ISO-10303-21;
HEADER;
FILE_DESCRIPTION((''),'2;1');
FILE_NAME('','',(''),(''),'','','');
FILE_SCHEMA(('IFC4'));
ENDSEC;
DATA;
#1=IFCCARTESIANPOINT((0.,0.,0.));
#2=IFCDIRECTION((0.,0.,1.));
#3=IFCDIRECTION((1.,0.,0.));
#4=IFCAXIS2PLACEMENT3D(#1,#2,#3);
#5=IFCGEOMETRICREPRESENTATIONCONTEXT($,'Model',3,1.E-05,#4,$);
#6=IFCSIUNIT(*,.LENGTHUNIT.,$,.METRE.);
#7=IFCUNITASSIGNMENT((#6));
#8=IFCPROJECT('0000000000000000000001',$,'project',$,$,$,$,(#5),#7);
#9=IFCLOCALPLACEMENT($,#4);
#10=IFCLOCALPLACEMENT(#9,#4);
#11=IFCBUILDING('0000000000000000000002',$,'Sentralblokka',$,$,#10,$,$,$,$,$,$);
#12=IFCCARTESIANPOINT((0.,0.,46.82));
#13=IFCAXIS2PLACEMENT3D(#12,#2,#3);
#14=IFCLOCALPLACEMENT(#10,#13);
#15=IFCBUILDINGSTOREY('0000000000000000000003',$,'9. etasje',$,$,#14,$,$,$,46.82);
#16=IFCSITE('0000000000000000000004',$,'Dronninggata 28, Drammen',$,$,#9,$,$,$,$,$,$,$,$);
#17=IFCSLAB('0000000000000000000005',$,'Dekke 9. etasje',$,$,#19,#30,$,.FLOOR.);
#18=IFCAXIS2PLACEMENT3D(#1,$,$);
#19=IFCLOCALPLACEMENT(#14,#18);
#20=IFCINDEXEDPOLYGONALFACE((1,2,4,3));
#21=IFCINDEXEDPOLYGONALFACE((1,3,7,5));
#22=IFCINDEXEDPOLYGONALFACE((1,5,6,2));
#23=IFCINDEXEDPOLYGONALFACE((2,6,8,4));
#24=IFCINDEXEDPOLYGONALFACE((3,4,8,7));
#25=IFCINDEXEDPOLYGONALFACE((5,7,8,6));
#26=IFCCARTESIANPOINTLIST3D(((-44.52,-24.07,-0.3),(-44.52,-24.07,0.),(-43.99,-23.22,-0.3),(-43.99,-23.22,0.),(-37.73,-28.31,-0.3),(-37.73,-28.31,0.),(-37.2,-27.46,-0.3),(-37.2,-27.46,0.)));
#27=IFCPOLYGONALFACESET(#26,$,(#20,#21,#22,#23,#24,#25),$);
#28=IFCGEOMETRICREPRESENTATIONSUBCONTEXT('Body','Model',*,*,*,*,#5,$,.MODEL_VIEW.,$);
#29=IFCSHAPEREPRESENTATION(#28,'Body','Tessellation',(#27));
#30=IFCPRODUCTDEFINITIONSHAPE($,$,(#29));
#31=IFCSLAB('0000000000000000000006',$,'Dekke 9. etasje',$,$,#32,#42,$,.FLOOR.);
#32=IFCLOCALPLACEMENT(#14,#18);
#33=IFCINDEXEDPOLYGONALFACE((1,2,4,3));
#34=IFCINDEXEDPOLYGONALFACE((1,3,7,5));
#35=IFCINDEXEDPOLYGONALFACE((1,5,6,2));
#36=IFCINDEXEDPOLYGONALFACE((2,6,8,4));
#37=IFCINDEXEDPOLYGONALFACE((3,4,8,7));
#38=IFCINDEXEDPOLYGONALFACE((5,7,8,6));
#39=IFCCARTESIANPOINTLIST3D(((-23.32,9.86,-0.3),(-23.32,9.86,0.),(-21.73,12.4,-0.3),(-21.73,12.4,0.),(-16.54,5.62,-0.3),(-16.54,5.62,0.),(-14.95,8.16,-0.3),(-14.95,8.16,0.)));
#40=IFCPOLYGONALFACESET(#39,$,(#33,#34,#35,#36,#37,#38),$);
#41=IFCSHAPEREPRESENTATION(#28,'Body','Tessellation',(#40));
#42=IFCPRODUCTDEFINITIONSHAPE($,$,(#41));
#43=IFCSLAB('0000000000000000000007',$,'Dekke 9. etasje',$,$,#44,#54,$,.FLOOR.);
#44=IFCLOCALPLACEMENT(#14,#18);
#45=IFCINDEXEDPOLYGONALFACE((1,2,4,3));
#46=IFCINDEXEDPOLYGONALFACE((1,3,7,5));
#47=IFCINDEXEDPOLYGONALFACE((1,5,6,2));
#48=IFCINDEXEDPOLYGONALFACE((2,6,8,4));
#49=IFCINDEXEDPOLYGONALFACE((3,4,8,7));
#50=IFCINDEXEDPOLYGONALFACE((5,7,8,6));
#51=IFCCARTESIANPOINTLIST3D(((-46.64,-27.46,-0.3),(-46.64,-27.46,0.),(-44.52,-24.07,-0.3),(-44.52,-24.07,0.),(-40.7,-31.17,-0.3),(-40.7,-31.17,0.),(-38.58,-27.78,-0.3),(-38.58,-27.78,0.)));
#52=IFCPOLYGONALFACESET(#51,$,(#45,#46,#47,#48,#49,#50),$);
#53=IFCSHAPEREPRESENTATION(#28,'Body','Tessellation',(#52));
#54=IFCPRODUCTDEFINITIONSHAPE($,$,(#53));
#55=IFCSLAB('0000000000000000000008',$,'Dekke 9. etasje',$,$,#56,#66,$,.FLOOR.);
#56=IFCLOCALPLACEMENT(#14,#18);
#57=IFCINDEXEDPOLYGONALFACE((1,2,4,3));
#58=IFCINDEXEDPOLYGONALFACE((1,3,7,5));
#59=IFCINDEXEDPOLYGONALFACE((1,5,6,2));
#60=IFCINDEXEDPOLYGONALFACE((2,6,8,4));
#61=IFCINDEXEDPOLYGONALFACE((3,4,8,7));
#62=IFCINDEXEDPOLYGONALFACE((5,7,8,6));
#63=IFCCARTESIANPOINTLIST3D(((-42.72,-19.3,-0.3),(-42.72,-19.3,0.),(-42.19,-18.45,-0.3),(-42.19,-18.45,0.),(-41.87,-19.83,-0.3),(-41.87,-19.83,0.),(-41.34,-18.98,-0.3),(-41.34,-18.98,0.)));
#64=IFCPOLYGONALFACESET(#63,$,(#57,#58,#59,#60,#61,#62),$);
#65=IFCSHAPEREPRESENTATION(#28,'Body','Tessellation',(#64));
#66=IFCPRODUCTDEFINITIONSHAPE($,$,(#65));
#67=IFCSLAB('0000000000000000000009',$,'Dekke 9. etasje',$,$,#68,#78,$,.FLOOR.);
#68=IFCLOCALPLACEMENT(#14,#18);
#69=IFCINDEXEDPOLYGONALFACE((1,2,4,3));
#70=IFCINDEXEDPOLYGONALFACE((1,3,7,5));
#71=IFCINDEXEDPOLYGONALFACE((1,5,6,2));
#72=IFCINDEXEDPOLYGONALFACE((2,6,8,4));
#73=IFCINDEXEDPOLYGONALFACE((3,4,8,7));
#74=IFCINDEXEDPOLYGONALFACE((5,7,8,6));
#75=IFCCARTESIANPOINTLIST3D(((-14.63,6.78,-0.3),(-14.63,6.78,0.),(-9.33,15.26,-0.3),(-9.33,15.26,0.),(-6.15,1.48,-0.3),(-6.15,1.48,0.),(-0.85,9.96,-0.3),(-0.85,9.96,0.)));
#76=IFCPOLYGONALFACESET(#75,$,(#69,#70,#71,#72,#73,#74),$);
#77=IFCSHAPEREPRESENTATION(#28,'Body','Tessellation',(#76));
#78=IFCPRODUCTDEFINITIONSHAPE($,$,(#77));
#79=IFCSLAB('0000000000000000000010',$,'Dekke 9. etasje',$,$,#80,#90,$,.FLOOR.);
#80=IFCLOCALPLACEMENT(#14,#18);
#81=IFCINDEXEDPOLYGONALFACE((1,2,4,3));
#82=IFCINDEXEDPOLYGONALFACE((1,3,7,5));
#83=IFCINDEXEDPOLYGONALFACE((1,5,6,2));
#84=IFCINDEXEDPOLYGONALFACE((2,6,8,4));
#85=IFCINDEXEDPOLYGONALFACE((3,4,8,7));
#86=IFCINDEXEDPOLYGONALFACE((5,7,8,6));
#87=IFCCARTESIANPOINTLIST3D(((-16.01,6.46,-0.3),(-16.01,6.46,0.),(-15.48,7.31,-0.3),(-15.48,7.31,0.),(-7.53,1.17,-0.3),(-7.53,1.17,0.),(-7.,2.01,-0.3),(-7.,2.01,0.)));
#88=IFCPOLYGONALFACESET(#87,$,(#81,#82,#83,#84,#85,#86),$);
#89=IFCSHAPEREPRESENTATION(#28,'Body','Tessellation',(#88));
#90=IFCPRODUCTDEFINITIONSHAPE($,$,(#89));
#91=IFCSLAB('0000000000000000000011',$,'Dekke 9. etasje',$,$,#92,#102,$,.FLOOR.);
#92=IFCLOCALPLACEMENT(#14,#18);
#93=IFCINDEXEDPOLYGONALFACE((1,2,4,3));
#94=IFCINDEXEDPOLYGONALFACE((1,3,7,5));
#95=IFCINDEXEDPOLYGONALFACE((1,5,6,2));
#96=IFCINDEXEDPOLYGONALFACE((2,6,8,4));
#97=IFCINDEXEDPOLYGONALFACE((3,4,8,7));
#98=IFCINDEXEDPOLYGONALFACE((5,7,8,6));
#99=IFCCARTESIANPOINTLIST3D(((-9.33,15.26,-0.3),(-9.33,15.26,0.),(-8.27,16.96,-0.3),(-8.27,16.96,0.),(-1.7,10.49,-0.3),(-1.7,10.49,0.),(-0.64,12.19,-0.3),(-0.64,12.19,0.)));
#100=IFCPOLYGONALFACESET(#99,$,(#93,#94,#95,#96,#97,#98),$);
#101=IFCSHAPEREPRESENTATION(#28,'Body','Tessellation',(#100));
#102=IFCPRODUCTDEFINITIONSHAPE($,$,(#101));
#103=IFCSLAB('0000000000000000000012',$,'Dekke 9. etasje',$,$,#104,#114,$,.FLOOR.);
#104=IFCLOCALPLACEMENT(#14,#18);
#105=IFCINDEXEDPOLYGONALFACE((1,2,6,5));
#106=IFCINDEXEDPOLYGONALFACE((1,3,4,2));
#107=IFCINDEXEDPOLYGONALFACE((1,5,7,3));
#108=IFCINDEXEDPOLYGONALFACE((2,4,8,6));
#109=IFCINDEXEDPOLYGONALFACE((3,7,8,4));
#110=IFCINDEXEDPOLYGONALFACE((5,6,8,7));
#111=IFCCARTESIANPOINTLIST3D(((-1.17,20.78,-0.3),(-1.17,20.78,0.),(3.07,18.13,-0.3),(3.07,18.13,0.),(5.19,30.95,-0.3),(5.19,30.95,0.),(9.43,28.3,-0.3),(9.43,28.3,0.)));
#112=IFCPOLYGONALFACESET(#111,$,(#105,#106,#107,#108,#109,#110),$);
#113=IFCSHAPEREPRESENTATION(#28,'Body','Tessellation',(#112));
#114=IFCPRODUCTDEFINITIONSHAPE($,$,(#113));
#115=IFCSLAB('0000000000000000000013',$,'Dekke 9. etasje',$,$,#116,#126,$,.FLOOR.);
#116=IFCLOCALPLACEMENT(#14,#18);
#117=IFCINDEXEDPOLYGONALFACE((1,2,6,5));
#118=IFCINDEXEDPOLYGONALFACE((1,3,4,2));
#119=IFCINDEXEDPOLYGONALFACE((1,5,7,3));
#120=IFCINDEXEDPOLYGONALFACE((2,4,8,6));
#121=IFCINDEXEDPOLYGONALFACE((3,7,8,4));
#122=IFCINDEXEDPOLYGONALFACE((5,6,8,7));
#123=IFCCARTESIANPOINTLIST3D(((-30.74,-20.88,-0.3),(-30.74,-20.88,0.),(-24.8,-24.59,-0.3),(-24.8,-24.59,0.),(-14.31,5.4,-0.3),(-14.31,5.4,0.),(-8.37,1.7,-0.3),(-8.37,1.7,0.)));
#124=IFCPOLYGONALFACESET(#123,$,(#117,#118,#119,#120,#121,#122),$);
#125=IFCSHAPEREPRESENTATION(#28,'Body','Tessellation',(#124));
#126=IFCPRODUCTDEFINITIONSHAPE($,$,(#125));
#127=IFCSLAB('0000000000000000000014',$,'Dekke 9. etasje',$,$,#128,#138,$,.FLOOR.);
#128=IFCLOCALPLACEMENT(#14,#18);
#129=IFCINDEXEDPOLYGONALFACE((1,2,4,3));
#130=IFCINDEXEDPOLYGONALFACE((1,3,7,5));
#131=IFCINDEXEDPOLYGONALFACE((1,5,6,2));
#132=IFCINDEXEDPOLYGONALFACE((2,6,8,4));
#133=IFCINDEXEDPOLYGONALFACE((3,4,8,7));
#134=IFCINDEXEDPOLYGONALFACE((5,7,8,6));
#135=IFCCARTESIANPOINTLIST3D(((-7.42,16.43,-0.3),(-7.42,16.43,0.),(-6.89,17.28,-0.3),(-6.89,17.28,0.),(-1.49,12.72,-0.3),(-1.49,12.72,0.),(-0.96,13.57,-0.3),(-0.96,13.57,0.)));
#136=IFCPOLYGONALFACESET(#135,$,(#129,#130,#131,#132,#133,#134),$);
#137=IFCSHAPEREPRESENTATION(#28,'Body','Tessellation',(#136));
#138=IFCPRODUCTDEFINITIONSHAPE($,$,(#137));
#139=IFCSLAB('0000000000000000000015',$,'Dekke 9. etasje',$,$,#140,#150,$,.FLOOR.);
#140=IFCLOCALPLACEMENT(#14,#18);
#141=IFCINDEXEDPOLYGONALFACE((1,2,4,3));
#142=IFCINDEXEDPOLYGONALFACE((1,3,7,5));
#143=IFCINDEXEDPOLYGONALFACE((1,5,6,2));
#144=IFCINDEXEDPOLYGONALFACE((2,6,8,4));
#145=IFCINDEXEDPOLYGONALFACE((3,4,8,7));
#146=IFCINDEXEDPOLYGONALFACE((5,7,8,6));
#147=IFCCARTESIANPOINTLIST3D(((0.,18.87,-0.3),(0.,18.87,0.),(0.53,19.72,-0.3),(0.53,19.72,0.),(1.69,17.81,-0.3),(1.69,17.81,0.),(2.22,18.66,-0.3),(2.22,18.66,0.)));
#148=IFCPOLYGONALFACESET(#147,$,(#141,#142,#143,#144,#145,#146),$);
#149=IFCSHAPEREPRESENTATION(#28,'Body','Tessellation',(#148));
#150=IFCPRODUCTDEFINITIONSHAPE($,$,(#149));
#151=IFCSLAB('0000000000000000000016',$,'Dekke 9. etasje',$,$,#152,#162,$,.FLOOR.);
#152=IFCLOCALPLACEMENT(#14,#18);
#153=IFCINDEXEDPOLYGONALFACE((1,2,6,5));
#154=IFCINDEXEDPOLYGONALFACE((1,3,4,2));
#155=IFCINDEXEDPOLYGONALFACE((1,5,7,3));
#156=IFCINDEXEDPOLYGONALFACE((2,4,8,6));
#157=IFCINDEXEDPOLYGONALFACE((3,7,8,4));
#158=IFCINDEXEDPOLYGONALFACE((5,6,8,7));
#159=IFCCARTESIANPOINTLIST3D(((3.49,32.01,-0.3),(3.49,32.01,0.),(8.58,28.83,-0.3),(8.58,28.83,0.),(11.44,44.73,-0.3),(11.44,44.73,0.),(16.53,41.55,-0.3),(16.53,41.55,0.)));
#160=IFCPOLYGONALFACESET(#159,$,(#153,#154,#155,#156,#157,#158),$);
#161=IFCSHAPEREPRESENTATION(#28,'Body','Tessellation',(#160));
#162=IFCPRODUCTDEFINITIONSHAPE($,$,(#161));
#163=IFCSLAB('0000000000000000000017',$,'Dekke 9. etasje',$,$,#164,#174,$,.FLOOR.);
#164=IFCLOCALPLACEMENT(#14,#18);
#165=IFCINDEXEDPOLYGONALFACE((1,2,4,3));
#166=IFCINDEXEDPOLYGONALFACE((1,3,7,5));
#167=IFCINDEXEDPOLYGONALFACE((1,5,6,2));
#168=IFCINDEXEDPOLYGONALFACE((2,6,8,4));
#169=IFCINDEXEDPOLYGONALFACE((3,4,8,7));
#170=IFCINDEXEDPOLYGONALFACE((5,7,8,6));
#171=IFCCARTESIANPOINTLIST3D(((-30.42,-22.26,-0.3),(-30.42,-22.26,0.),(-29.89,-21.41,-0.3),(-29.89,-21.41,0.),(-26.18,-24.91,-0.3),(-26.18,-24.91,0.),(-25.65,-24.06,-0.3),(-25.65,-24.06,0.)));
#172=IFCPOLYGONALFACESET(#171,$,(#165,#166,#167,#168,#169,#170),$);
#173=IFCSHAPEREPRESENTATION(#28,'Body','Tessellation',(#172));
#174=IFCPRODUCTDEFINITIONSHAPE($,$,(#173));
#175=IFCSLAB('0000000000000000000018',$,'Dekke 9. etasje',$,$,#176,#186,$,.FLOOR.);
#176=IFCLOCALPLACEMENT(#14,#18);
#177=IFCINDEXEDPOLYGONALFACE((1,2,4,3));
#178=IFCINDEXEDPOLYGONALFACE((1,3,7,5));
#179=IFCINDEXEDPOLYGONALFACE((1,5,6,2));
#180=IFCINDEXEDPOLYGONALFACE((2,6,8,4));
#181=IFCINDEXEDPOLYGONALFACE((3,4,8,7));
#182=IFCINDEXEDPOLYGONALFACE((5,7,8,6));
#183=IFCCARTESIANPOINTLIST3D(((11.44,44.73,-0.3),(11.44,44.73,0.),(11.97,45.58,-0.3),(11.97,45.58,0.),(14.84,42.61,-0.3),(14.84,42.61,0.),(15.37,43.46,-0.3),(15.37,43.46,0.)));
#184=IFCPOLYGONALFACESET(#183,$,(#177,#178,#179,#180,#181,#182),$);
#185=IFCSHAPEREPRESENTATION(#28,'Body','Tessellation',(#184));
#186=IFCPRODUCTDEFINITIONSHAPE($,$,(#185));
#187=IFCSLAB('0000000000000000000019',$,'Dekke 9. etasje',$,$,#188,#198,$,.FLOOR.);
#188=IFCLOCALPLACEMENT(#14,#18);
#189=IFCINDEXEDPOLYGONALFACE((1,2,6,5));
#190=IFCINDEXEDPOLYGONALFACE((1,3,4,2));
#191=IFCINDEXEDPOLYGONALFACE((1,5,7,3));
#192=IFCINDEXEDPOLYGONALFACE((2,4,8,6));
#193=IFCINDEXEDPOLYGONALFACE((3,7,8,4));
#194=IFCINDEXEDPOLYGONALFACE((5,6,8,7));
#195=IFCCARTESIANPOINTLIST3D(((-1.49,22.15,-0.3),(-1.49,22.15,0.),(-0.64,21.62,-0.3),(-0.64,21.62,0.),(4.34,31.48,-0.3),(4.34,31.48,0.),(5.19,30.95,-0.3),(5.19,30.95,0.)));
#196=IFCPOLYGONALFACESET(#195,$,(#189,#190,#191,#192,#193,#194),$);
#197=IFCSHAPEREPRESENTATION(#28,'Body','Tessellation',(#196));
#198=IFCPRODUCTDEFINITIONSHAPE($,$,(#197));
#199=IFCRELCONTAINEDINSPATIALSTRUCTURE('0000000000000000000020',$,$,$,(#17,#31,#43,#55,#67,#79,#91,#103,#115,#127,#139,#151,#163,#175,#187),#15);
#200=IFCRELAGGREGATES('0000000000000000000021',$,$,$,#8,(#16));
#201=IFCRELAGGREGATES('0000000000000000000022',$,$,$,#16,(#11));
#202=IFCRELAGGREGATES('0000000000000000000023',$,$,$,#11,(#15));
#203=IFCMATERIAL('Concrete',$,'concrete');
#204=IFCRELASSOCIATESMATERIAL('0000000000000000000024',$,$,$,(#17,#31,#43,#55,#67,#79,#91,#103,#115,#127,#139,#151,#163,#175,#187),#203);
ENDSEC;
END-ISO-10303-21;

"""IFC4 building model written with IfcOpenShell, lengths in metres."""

from ifc_helpers import new_model, si_unit, frame, origin_with_axes, place, context, subcontext, project, spatial, polyline, outline, extrude, material, element, save


model = new_model("IFC4")

# Units and contexts
model_context = context("Model", 3, precision=1e-05, world=origin_with_axes())
body_context = subcontext(model_context, "Body", "Model", "MODEL_VIEW")
ifc_project = project(units=[si_unit("LENGTHUNIT", "METRE")], contexts=[model_context])

# Site, building, storey
site_placement = place(None, origin_with_axes())
site = spatial("IfcSite", under=ifc_project, at=site_placement, Name="Dronninggata 28, Drammen")
building_placement = place(site_placement, origin_with_axes())
building = spatial("IfcBuilding", under=site, at=building_placement, Name="Sentralblokka")
storey_placement = place(building_placement, frame((0.0, 0.0, 46.82), z_axis=(0.0, 0.0, 1.0), x_axis=(1.0, 0.0, 0.0)))
storey = spatial("IfcBuildingStorey", under=building, at=storey_placement, Name="9. etasje", Elevation=46.82)

# Slabs
ifc_material = material(Name="Concrete", Category="concrete")
slab_1_placement = place(storey_placement, frame((0.0, 0.0, -46.82), z_axis=(0.0, 0.0, 1.0), x_axis=(1.0, 0.0, 0.0)))
element("IfcSlab", 1, at=slab_1_placement, inside=storey, material=ifc_material, Name="Dekke 9. etasje", PredefinedType="FLOOR", context=body_context, shape_type="SweptSolid", body=[
    extrude(outline(polyline([(-37.73, -28.31), (-37.2, -27.46), (-43.99, -23.22), (-44.52, -24.07), (-37.73, -28.31)])), frame((0.0, 0.0, 46.52)), (0.0, 0.0, 1.0), 0.3),
])
slab_2_placement = place(storey_placement, frame((0.0, 0.0, -46.82), z_axis=(0.0, 0.0, 1.0), x_axis=(1.0, 0.0, 0.0)))
element("IfcSlab", 2, at=slab_2_placement, inside=storey, material=ifc_material, Name="Dekke 9. etasje", PredefinedType="FLOOR", context=body_context, shape_type="SweptSolid", body=[
    extrude(outline(polyline([(-16.54, 5.62), (-14.95, 8.16), (-21.73, 12.4), (-23.32, 9.86), (-16.54, 5.62)])), frame((0.0, 0.0, 46.52)), (0.0, 0.0, 1.0), 0.3),
])
slab_3_placement = place(storey_placement, frame((0.0, 0.0, -46.82), z_axis=(0.0, 0.0, 1.0), x_axis=(1.0, 0.0, 0.0)))
element("IfcSlab", 3, at=slab_3_placement, inside=storey, material=ifc_material, Name="Dekke 9. etasje", PredefinedType="FLOOR", context=body_context, shape_type="SweptSolid", body=[
    extrude(outline(polyline([(-40.7, -31.17), (-38.58, -27.78), (-44.52, -24.07), (-46.64, -27.46), (-40.7, -31.17)])), frame((0.0, 0.0, 46.52)), (0.0, 0.0, 1.0), 0.3),
])
slab_4_placement = place(storey_placement, frame((0.0, 0.0, -46.82), z_axis=(0.0, 0.0, 1.0), x_axis=(1.0, 0.0, 0.0)))
element("IfcSlab", 4, at=slab_4_placement, inside=storey, material=ifc_material, Name="Dekke 9. etasje", PredefinedType="FLOOR", context=body_context, shape_type="SweptSolid", body=[
    extrude(outline(polyline([(-41.87, -19.83), (-41.34, -18.98), (-42.19, -18.45), (-42.72, -19.3), (-41.87, -19.83)])), frame((0.0, 0.0, 46.52)), (0.0, 0.0, 1.0), 0.3),
])
slab_5_placement = place(storey_placement, frame((0.0, 0.0, -46.82), z_axis=(0.0, 0.0, 1.0), x_axis=(1.0, 0.0, 0.0)))
element("IfcSlab", 5, at=slab_5_placement, inside=storey, material=ifc_material, Name="Dekke 9. etasje", PredefinedType="FLOOR", context=body_context, shape_type="SweptSolid", body=[
    extrude(outline(polyline([(-6.15, 1.48), (-0.85, 9.96), (-9.33, 15.26), (-14.63, 6.78), (-6.15, 1.48)])), frame((0.0, 0.0, 46.52)), (0.0, 0.0, 1.0), 0.3),
])
slab_6_placement = place(storey_placement, frame((0.0, 0.0, -46.82), z_axis=(0.0, 0.0, 1.0), x_axis=(1.0, 0.0, 0.0)))
element("IfcSlab", 6, at=slab_6_placement, inside=storey, material=ifc_material, Name="Dekke 9. etasje", PredefinedType="FLOOR", context=body_context, shape_type="SweptSolid", body=[
    extrude(outline(polyline([(-7.53, 1.17), (-7.0, 2.01), (-15.48, 7.31), (-16.01, 6.46), (-7.53, 1.17)])), frame((0.0, 0.0, 46.52)), (0.0, 0.0, 1.0), 0.3),
])
slab_7_placement = place(storey_placement, frame((0.0, 0.0, -46.82), z_axis=(0.0, 0.0, 1.0), x_axis=(1.0, 0.0, 0.0)))
element("IfcSlab", 7, at=slab_7_placement, inside=storey, material=ifc_material, Name="Dekke 9. etasje", PredefinedType="FLOOR", context=body_context, shape_type="SweptSolid", body=[
    extrude(outline(polyline([(-1.7, 10.49), (-0.64, 12.19), (-8.27, 16.96), (-9.33, 15.26), (-1.7, 10.49)])), frame((0.0, 0.0, 46.52)), (0.0, 0.0, 1.0), 0.3),
])
slab_8_placement = place(storey_placement, frame((0.0, 0.0, -46.82), z_axis=(0.0, 0.0, 1.0), x_axis=(1.0, 0.0, 0.0)))
element("IfcSlab", 8, at=slab_8_placement, inside=storey, material=ifc_material, Name="Dekke 9. etasje", PredefinedType="FLOOR", context=body_context, shape_type="SweptSolid", body=[
    extrude(outline(polyline([(3.07, 18.13), (9.43, 28.3), (5.19, 30.95), (-1.17, 20.78), (3.07, 18.13)])), frame((0.0, 0.0, 46.52)), (0.0, 0.0, 1.0), 0.3),
])
slab_9_placement = place(storey_placement, frame((0.0, 0.0, -46.82), z_axis=(0.0, 0.0, 1.0), x_axis=(1.0, 0.0, 0.0)))
element("IfcSlab", 9, at=slab_9_placement, inside=storey, material=ifc_material, Name="Dekke 9. etasje", PredefinedType="FLOOR", context=body_context, shape_type="SweptSolid", body=[
    extrude(outline(polyline([(-24.8, -24.59), (-8.37, 1.7), (-14.31, 5.4), (-30.74, -20.88), (-24.8, -24.59)])), frame((0.0, 0.0, 46.52)), (0.0, 0.0, 1.0), 0.3),
])
slab_10_placement = place(storey_placement, frame((0.0, 0.0, -46.82), z_axis=(0.0, 0.0, 1.0), x_axis=(1.0, 0.0, 0.0)))
element("IfcSlab", 10, at=slab_10_placement, inside=storey, material=ifc_material, Name="Dekke 9. etasje", PredefinedType="FLOOR", context=body_context, shape_type="SweptSolid", body=[
    extrude(outline(polyline([(-1.49, 12.72), (-0.96, 13.57), (-6.89, 17.28), (-7.42, 16.43), (-1.49, 12.72)])), frame((0.0, 0.0, 46.52)), (0.0, 0.0, 1.0), 0.3),
])
slab_11_placement = place(storey_placement, frame((0.0, 0.0, -46.82), z_axis=(0.0, 0.0, 1.0), x_axis=(1.0, 0.0, 0.0)))
element("IfcSlab", 11, at=slab_11_placement, inside=storey, material=ifc_material, Name="Dekke 9. etasje", PredefinedType="FLOOR", context=body_context, shape_type="SweptSolid", body=[
    extrude(outline(polyline([(1.69, 17.81), (2.22, 18.66), (0.53, 19.72), (0.0, 18.87), (1.69, 17.81)])), frame((0.0, 0.0, 46.52)), (0.0, 0.0, 1.0), 0.3),
])
slab_12_placement = place(storey_placement, frame((0.0, 0.0, -46.82), z_axis=(0.0, 0.0, 1.0), x_axis=(1.0, 0.0, 0.0)))
element("IfcSlab", 12, at=slab_12_placement, inside=storey, material=ifc_material, Name="Dekke 9. etasje", PredefinedType="FLOOR", context=body_context, shape_type="SweptSolid", body=[
    extrude(outline(polyline([(8.58, 28.83), (16.53, 41.55), (11.44, 44.73), (3.49, 32.01), (8.58, 28.83)])), frame((0.0, 0.0, 46.52)), (0.0, 0.0, 1.0), 0.3),
])
slab_13_placement = place(storey_placement, frame((0.0, 0.0, -46.82), z_axis=(0.0, 0.0, 1.0), x_axis=(1.0, 0.0, 0.0)))
element("IfcSlab", 13, at=slab_13_placement, inside=storey, material=ifc_material, Name="Dekke 9. etasje", PredefinedType="FLOOR", context=body_context, shape_type="SweptSolid", body=[
    extrude(outline(polyline([(-26.18, -24.91), (-25.65, -24.06), (-29.89, -21.41), (-30.42, -22.26), (-26.18, -24.91)])), frame((0.0, 0.0, 46.52)), (0.0, 0.0, 1.0), 0.3),
])
slab_14_placement = place(storey_placement, frame((0.0, 0.0, -46.82), z_axis=(0.0, 0.0, 1.0), x_axis=(1.0, 0.0, 0.0)))
element("IfcSlab", 14, at=slab_14_placement, inside=storey, material=ifc_material, Name="Dekke 9. etasje", PredefinedType="FLOOR", context=body_context, shape_type="SweptSolid", body=[
    extrude(outline(polyline([(14.84, 42.61), (15.37, 43.46), (11.97, 45.58), (11.44, 44.73), (14.84, 42.61)])), frame((0.0, 0.0, 46.52)), (0.0, 0.0, 1.0), 0.3),
])
slab_15_placement = place(storey_placement, frame((0.0, 0.0, -46.82), z_axis=(0.0, 0.0, 1.0), x_axis=(1.0, 0.0, 0.0)))
element("IfcSlab", 15, at=slab_15_placement, inside=storey, material=ifc_material, Name="Dekke 9. etasje", PredefinedType="FLOOR", context=body_context, shape_type="SweptSolid", body=[
    extrude(outline(polyline([(-0.64, 21.62), (5.19, 30.95), (4.34, 31.48), (-1.49, 22.15), (-0.64, 21.62)])), frame((0.0, 0.0, 46.52)), (0.0, 0.0, 1.0), 0.3),
])

save(model, "model.ifc")
